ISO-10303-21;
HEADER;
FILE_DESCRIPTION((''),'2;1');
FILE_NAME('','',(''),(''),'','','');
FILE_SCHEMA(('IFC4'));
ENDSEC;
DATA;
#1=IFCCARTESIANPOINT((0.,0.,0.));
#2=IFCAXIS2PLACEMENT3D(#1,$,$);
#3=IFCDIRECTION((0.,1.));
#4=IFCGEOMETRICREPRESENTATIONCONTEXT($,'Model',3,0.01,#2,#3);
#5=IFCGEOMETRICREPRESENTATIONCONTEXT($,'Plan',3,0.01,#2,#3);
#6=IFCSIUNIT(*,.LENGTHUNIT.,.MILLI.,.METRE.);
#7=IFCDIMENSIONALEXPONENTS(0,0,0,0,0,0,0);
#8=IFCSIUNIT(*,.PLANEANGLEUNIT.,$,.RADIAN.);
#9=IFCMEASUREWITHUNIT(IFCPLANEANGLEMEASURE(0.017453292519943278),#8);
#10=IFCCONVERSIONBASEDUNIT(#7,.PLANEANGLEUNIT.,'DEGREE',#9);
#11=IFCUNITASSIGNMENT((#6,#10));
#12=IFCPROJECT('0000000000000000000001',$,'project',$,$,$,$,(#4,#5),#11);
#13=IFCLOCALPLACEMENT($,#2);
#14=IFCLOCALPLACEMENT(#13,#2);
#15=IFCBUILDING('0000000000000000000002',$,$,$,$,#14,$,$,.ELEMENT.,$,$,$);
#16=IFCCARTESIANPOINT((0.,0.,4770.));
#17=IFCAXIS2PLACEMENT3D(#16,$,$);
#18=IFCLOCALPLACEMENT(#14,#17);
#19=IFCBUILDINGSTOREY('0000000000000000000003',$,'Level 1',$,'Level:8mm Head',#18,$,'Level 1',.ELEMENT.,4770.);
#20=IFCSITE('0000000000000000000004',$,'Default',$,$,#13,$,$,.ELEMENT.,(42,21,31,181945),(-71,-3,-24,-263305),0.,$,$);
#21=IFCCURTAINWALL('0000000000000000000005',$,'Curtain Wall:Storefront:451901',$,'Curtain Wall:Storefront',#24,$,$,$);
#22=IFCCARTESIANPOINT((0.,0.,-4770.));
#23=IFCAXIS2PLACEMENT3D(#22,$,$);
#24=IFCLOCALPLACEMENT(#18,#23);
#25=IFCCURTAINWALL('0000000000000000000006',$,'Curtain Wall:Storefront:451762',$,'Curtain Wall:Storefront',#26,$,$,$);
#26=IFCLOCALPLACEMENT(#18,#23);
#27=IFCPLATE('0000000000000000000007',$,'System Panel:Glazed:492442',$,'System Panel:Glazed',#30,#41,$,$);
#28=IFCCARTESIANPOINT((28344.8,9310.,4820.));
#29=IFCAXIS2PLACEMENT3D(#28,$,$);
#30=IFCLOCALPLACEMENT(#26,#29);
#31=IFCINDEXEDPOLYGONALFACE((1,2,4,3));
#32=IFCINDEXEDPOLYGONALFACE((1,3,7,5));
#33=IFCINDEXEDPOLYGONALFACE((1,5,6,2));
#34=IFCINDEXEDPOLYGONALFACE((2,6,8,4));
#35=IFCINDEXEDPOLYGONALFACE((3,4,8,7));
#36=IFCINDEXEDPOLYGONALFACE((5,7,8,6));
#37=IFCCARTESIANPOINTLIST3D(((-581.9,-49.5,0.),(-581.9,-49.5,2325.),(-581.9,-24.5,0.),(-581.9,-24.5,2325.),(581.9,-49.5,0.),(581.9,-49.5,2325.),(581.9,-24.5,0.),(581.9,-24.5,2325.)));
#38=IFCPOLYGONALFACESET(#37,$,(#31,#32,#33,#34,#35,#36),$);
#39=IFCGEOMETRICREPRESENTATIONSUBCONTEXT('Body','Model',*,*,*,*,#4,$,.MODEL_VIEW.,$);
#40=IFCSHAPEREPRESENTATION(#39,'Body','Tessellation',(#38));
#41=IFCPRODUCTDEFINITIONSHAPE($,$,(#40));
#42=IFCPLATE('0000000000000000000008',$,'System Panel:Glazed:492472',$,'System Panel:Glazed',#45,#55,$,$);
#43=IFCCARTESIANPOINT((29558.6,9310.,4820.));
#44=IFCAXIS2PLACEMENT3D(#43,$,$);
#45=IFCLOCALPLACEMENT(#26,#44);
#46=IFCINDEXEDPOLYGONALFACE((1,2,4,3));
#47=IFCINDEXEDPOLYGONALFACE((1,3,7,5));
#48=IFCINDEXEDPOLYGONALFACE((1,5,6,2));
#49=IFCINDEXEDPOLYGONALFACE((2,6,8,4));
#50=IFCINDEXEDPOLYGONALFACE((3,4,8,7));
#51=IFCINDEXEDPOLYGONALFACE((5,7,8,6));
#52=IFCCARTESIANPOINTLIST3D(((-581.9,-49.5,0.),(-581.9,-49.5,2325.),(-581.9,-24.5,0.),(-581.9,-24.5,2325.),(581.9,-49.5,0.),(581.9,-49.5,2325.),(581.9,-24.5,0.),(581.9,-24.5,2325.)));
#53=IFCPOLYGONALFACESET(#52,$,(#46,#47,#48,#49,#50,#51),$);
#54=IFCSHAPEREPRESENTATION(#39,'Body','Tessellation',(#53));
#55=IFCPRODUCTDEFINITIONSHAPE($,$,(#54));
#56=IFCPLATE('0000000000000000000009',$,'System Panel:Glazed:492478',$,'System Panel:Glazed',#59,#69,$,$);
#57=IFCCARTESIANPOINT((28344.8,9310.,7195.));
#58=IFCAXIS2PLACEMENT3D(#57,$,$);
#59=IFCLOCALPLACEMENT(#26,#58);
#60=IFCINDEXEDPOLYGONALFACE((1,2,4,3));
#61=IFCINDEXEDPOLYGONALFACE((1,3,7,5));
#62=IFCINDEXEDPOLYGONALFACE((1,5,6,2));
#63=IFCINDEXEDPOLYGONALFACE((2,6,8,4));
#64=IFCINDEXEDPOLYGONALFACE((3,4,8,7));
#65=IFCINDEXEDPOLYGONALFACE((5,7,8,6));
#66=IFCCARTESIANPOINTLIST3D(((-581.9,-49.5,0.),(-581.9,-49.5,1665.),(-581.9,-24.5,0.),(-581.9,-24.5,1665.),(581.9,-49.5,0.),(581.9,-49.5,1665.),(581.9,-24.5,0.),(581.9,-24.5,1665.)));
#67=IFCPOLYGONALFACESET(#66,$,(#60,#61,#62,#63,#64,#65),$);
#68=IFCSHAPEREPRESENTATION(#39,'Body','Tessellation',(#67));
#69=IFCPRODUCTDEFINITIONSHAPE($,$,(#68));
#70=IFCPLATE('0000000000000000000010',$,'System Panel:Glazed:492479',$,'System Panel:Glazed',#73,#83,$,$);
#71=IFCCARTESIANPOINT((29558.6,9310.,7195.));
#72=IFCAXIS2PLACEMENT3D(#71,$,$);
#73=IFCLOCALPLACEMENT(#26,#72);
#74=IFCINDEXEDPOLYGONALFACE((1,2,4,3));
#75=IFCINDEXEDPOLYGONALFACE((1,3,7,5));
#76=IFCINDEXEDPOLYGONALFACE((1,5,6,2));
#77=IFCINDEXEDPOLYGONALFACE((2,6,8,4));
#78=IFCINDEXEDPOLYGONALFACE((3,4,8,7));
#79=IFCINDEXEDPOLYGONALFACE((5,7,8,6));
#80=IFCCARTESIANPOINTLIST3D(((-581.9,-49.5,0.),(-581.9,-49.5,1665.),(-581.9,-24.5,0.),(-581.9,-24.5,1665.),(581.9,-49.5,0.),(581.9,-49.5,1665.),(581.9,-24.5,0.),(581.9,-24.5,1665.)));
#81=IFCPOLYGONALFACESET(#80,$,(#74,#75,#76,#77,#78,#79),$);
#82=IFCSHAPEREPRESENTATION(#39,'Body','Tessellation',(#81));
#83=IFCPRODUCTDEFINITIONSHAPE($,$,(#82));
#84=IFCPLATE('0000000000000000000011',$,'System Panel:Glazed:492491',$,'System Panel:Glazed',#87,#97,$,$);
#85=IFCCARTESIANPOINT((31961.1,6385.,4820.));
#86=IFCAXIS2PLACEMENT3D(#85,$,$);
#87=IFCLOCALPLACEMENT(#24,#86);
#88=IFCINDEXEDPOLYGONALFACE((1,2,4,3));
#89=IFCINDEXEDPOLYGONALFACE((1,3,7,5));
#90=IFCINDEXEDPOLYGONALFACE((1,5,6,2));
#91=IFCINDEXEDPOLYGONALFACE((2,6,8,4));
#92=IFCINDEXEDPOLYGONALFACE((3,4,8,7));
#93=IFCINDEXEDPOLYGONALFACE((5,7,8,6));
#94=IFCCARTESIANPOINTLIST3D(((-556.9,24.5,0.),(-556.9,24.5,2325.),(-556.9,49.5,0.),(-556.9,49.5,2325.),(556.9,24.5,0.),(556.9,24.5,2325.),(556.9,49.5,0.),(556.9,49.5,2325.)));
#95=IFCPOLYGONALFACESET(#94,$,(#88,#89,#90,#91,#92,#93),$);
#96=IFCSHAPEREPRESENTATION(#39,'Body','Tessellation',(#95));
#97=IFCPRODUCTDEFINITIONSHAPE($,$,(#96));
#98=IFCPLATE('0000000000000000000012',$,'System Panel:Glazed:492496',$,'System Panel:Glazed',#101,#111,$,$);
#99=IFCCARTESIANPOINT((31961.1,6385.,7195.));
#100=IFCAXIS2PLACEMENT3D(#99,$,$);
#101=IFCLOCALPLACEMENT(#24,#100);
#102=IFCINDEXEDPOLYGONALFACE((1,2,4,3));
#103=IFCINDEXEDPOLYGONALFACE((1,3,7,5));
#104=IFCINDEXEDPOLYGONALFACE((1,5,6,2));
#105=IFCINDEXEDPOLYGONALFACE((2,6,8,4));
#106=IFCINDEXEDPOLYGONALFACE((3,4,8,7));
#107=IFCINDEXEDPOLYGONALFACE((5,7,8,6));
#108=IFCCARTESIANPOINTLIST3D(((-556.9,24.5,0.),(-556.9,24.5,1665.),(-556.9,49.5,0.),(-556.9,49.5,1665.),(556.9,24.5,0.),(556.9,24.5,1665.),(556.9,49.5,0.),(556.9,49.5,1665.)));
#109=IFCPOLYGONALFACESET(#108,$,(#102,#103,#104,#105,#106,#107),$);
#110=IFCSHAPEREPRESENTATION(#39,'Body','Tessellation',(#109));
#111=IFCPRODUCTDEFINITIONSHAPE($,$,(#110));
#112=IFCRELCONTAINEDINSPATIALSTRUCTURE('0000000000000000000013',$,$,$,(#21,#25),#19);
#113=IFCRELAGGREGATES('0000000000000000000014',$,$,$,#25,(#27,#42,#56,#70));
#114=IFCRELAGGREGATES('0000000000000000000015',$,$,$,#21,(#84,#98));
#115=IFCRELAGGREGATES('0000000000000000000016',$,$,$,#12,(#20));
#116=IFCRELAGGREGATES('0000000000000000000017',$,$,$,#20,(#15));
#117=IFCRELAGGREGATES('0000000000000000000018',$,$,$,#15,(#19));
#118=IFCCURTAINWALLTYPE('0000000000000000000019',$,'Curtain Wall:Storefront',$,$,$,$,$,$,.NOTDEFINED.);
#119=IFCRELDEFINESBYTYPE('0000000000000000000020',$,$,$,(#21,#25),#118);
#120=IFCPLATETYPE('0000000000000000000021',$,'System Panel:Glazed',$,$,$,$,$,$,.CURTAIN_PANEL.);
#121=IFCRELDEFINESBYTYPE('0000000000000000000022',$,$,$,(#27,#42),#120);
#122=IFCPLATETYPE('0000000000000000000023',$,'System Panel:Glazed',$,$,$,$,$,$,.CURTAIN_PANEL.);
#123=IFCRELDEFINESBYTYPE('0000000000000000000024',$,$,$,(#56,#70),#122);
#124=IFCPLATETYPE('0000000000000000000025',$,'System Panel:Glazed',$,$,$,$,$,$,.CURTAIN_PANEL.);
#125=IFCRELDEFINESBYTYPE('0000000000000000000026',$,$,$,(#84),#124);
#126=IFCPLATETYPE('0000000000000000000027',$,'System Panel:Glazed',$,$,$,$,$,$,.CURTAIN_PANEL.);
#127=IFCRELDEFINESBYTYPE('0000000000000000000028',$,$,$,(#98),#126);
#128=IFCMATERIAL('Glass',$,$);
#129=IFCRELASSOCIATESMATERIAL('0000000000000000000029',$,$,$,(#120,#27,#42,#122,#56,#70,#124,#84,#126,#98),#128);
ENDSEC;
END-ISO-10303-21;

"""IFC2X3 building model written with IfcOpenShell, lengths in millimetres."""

from ifc_helpers import new_model, entity, si_unit, converted_unit, direction, frame, frame_2d, origin, origin_2d_with_axis, place, context, subcontext, project, spatial, rectangle, extrude, source, transform, mapped, material, type_object, type_shapes, element, aggregate, save


model = new_model("IFC2X3")

# Units and contexts
model_context = context("Model", 3, precision=0.01, world=origin(), true_north=direction((0.0, 1.0)))
plan_context = context("Plan", 3, precision=0.01, world=origin(), true_north=direction((0.0, 1.0)))
body_context = subcontext(model_context, "Body", "Model", "MODEL_VIEW")
ifc_project = project(units=[si_unit("LENGTHUNIT", "METRE", prefix="MILLI"), converted_unit("PLANEANGLEUNIT", "DEGREE", entity("IfcPlaneAngleMeasure", 0.017453292519943278), si_unit("PLANEANGLEUNIT", "RADIAN"), dimensions=[0, 0, 0, 0, 0, 0, 0])], contexts=[model_context, plan_context])

# Site, building, storey
site_placement = place(None, origin())
site = spatial("IfcSite", under=ifc_project, at=site_placement, Name="Default", CompositionType="ELEMENT", RefLatitude=(42, 21, 31, 181945), RefLongitude=(-71, -3, -24, -263305), RefElevation=0.0)
building_placement = place(site_placement, origin())
building = spatial("IfcBuilding", under=site, at=building_placement, CompositionType="ELEMENT")
storey_placement = place(building_placement, frame((0.0, 0.0, 4770.0)))
storey = spatial("IfcBuildingStorey", under=building, at=storey_placement, Name="Level 1", ObjectType="Level:8mm Head", LongName="Level 1", CompositionType="ELEMENT", Elevation=4770.0)

# Curtain walls
curtain_wall_type = type_object("IfcCurtainWallType", Name="Curtain Wall:Storefront", PredefinedType="NOTDEFINED")
curtain_wall_1_placement = place(storey_placement, frame((0.0, 0.0, -4770.0)))
curtain_wall_1 = element("IfcCurtainWall", 1, at=curtain_wall_1_placement, inside=storey, type_object=curtain_wall_type, Name="Curtain Wall:Storefront:451901", ObjectType="Curtain Wall:Storefront")
curtain_wall_2_placement = place(storey_placement, frame((0.0, 0.0, -4770.0)))
curtain_wall_2 = element("IfcCurtainWall", 2, at=curtain_wall_2_placement, inside=storey, type_object=curtain_wall_type, Name="Curtain Wall:Storefront:451762", ObjectType="Curtain Wall:Storefront")

# Plates
ifc_material_1 = material(Name="Glass")
plate_type_1 = type_object("IfcPlateType", Name="System Panel:Glazed", PredefinedType="CURTAIN_PANEL", material=ifc_material_1)
shared_shape_1 = source(origin(), body_context, "Body", "SweptSolid", [
    extrude(rectangle(XDim=25.0, YDim=1163.8, at=frame_2d((0.0, 0.0), x_axis=(1.0, 0.0))), frame((0.0, -37.0, 0.0), z_axis=(0.0, 0.0, 1.0), x_axis=(0.0, 1.0, 0.0)), (0.0, 0.0, 1.0), 2325.0),
])
type_shapes(plate_type_1, [shared_shape_1])
plate_1_placement = place(curtain_wall_2_placement, frame((28344.8, 9310.0, 4820.0)))
plate_1 = element("IfcPlate", 3, at=plate_1_placement, type_object=plate_type_1, material=ifc_material_1, Name="System Panel:Glazed:492442", ObjectType="System Panel:Glazed", context=body_context, shape_type="MappedRepresentation", body=[
    mapped(shared_shape_1, transform((0.0, 0.0, 0.0), scale=1.0)),
])
plate_2_placement = place(curtain_wall_2_placement, frame((29558.6, 9310.0, 4820.0)))
plate_2 = element("IfcPlate", 4, at=plate_2_placement, type_object=plate_type_1, material=ifc_material_1, Name="System Panel:Glazed:492472", ObjectType="System Panel:Glazed", context=body_context, shape_type="MappedRepresentation", body=[
    mapped(shared_shape_1, transform((0.0, 0.0, 0.0), scale=1.0)),
])
plate_type_2 = type_object("IfcPlateType", Name="System Panel:Glazed", PredefinedType="CURTAIN_PANEL", material=ifc_material_1)
shared_shape_2 = source(origin(), body_context, "Body", "SweptSolid", [
    extrude(rectangle(XDim=25.0, YDim=1163.8, at=frame_2d((0.0, 0.0), x_axis=(1.0, 0.0))), frame((0.0, -37.0, 0.0), z_axis=(0.0, 0.0, 1.0), x_axis=(0.0, 1.0, 0.0)), (0.0, 0.0, 1.0), 1665.0),
])
type_shapes(plate_type_2, [shared_shape_2])
plate_3_placement = place(curtain_wall_2_placement, frame((28344.8, 9310.0, 7195.0)))
plate_3 = element("IfcPlate", 5, at=plate_3_placement, type_object=plate_type_2, material=ifc_material_1, Name="System Panel:Glazed:492478", ObjectType="System Panel:Glazed", context=body_context, shape_type="MappedRepresentation", body=[
    mapped(shared_shape_2, transform((0.0, 0.0, 0.0), scale=1.0)),
])
plate_4_placement = place(curtain_wall_2_placement, frame((29558.6, 9310.0, 7195.0)))
plate_4 = element("IfcPlate", 6, at=plate_4_placement, type_object=plate_type_2, material=ifc_material_1, Name="System Panel:Glazed:492479", ObjectType="System Panel:Glazed", context=body_context, shape_type="MappedRepresentation", body=[
    mapped(shared_shape_2, transform((0.0, 0.0, 0.0), scale=1.0)),
])
aggregate(curtain_wall_2, [plate_1, plate_2, plate_3, plate_4])
plate_type_3 = type_object("IfcPlateType", Name="System Panel:Glazed", PredefinedType="CURTAIN_PANEL", material=ifc_material_1)
shared_shape_3 = source(origin(), body_context, "Body", "SweptSolid", [
    extrude(rectangle(XDim=25.0, YDim=1113.8, at=origin_2d_with_axis()), frame((0.0, 37.0, 0.0), z_axis=(0.0, 0.0, 1.0), x_axis=(0.0, 1.0, 0.0)), (0.0, 0.0, 1.0), 2325.0),
])
type_shapes(plate_type_3, [shared_shape_3])
plate_5_placement = place(curtain_wall_1_placement, frame((31961.1, 6385.0, 4820.0)))
plate_5 = element("IfcPlate", 7, at=plate_5_placement, type_object=plate_type_3, material=ifc_material_1, Name="System Panel:Glazed:492491", ObjectType="System Panel:Glazed", context=body_context, shape_type="MappedRepresentation", body=[
    mapped(shared_shape_3, transform((0.0, 0.0, 0.0), scale=1.0)),
])
plate_type_4 = type_object("IfcPlateType", Name="System Panel:Glazed", PredefinedType="CURTAIN_PANEL", material=ifc_material_1)
shared_shape_4 = source(origin(), body_context, "Body", "SweptSolid", [
    extrude(rectangle(XDim=25.0, YDim=1113.8, at=frame_2d((0.0, 0.0), x_axis=(1.0, 0.0))), frame((0.0, 37.0, 0.0), z_axis=(0.0, 0.0, 1.0), x_axis=(0.0, 1.0, 0.0)), (0.0, 0.0, 1.0), 1665.0),
])
type_shapes(plate_type_4, [shared_shape_4])
plate_6_placement = place(curtain_wall_1_placement, frame((31961.1, 6385.0, 7195.0)))
plate_6 = element("IfcPlate", 8, at=plate_6_placement, type_object=plate_type_4, material=ifc_material_1, Name="System Panel:Glazed:492496", ObjectType="System Panel:Glazed", context=body_context, shape_type="MappedRepresentation", body=[
    mapped(shared_shape_4, transform((0.0, 0.0, 0.0), scale=1.0)),
])
aggregate(curtain_wall_1, [plate_5, plate_6])

save(model, "model.ifc")
